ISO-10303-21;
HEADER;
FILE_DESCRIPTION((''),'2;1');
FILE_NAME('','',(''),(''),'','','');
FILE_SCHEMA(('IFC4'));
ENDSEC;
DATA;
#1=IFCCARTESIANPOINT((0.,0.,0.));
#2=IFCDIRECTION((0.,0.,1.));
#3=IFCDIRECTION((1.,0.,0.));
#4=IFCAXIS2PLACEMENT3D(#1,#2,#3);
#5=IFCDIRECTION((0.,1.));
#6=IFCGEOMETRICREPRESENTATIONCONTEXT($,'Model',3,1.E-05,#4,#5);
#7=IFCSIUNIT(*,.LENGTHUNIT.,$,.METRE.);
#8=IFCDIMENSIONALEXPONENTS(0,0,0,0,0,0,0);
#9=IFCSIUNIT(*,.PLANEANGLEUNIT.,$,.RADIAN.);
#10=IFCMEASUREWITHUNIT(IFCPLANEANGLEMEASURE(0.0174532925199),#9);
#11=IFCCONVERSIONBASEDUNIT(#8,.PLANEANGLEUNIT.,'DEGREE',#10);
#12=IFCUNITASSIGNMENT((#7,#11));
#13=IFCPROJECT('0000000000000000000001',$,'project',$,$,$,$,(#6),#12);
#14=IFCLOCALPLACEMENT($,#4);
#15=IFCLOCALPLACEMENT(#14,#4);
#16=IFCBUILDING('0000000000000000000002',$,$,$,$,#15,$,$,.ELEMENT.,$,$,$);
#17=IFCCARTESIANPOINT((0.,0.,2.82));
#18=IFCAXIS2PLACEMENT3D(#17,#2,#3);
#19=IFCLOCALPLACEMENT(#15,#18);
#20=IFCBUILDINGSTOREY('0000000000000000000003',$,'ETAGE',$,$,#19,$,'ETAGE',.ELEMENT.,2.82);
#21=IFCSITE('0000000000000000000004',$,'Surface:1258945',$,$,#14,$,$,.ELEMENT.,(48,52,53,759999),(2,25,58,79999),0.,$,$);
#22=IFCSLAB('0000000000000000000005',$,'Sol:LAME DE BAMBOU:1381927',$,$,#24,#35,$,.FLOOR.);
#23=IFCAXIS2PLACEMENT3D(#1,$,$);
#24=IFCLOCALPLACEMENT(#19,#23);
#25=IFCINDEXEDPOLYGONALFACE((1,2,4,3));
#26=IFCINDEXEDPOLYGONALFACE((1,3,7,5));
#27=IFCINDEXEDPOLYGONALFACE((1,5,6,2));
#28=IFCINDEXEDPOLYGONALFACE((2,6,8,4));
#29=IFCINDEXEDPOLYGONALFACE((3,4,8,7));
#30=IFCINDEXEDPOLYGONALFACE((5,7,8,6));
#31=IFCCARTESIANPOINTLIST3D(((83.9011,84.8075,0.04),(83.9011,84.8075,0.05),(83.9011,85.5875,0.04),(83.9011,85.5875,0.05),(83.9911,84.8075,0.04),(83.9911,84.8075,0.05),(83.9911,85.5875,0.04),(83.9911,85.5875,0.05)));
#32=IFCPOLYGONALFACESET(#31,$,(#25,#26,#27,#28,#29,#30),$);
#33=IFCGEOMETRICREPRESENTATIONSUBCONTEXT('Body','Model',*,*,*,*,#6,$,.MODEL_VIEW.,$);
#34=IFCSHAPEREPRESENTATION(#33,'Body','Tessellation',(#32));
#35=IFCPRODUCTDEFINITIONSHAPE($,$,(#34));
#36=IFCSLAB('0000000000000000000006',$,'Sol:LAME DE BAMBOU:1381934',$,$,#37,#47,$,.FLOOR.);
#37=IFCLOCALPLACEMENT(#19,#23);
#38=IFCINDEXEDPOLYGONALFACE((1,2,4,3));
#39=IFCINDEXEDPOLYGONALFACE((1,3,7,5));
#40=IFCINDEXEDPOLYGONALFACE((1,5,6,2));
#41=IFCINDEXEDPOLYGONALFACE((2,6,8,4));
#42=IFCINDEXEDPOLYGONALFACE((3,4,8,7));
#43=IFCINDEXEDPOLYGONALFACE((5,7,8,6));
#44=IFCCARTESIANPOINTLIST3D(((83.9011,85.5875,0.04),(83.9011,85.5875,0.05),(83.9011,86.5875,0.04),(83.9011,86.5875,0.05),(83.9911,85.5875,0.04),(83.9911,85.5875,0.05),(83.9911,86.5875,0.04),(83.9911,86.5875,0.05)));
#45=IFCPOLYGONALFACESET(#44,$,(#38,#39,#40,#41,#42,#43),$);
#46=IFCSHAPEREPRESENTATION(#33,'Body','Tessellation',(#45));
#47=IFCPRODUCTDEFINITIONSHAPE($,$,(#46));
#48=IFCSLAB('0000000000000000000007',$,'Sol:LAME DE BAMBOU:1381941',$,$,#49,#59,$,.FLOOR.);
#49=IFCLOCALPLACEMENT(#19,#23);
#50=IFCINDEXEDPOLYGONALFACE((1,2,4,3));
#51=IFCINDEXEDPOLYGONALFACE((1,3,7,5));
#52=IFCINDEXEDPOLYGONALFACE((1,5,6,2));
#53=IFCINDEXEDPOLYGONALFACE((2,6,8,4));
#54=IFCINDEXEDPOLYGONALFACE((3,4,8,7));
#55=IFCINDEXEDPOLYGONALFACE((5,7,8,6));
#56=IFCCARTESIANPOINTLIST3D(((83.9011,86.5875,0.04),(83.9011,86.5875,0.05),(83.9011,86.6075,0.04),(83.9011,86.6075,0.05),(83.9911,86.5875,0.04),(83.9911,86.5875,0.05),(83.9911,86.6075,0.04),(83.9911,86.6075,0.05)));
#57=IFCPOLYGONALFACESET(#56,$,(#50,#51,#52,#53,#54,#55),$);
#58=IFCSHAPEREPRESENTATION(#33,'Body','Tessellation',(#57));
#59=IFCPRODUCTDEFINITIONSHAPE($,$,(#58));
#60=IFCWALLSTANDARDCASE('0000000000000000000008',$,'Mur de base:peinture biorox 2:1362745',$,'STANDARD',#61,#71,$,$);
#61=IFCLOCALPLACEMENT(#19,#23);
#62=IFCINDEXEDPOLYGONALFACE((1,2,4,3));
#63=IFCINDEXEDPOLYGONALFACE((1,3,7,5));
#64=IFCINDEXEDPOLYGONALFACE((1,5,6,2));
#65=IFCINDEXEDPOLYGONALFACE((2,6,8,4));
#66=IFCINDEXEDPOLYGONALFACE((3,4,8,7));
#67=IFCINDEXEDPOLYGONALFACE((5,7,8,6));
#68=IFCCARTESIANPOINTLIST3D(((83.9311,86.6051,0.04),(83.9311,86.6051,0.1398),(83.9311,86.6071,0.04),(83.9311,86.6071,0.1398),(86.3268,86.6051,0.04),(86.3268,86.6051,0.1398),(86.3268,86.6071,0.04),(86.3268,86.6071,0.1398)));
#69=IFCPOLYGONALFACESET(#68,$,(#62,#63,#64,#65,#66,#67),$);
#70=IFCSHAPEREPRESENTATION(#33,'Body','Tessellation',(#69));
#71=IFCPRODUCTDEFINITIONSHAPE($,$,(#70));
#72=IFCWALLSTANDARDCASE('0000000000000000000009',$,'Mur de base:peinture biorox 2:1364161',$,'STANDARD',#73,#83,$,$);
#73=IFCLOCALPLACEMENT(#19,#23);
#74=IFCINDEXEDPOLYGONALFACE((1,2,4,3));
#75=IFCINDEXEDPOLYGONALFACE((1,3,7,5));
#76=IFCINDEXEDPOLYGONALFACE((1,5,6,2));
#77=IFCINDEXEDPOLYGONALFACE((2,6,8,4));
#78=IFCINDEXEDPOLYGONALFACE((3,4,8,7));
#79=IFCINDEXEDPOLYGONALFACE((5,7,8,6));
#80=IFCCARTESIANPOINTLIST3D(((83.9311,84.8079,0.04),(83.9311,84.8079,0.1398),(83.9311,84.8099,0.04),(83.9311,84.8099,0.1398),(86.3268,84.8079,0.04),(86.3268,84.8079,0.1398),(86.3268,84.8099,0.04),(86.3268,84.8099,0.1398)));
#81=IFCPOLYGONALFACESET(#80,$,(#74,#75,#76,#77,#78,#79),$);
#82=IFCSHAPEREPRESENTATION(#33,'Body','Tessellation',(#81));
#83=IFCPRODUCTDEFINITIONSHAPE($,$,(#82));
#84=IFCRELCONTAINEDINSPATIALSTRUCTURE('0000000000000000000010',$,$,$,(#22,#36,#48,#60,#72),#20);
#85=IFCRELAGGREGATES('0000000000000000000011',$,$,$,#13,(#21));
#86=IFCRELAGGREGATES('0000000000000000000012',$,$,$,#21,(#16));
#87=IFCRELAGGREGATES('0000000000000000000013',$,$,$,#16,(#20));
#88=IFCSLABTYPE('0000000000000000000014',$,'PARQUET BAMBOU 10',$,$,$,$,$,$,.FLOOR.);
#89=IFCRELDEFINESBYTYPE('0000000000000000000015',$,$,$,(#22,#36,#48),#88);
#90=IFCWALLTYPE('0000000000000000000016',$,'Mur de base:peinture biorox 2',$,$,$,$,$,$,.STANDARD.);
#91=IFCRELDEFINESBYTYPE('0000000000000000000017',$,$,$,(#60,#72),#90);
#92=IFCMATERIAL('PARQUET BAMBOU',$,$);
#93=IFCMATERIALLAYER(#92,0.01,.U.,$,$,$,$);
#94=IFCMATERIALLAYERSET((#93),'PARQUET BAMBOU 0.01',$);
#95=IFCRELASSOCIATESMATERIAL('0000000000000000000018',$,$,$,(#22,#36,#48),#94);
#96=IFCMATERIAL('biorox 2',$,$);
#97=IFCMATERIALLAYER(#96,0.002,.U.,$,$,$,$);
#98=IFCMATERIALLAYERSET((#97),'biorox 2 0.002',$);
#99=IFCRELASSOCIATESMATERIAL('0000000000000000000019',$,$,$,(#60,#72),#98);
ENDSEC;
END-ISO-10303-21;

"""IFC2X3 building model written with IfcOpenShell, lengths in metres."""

from ifc_helpers import new_model, entity, si_unit, converted_unit, direction, frame, origin_with_axes, place, context, subcontext, project, spatial, polyline, outline, extrude, clip, halfspace, material, layer, layer_set, layer_usage, type_object, element, save


model = new_model("IFC2X3")

# Units and contexts
model_context = context("Model", 3, precision=1e-05, world=origin_with_axes(), true_north=direction((0.0, 1.0)))
body_context = subcontext(model_context, "Body", "Model", "MODEL_VIEW")
ifc_project = project(units=[si_unit("LENGTHUNIT", "METRE"), converted_unit("PLANEANGLEUNIT", "DEGREE", entity("IfcPlaneAngleMeasure", 0.0174532925199), si_unit("PLANEANGLEUNIT", "RADIAN"), dimensions=[0, 0, 0, 0, 0, 0, 0])], contexts=[model_context])

# Site, building, storey
site_placement = place(None, origin_with_axes())
site = spatial("IfcSite", under=ifc_project, at=site_placement, Name="Surface:1258945", CompositionType="ELEMENT", RefLatitude=(48, 52, 53, 759999), RefLongitude=(2, 25, 58, 79999), RefElevation=0.0)
building_placement = place(site_placement, origin_with_axes())
building = spatial("IfcBuilding", under=site, at=building_placement, CompositionType="ELEMENT")
storey_placement = place(building_placement, frame((0.0, 0.0, 2.82), z_axis=(0.0, 0.0, 1.0), x_axis=(1.0, 0.0, 0.0)))
storey = spatial("IfcBuildingStorey", under=building, at=storey_placement, Name="ETAGE", LongName="ETAGE", CompositionType="ELEMENT", Elevation=2.82)

# Slabs
ifc_material_1 = material(Name="PARQUET BAMBOU")
ifc_layer_1 = layer(ifc_material_1, 0.01, ventilated="UNKNOWN")
ifc_layer_set_1 = layer_set([ifc_layer_1], Name="PARQUET BAMBOU 0.01")
slab_type = type_object("IfcSlabType", Name="PARQUET BAMBOU 10", PredefinedType="FLOOR")
ifc_layer_usage_1 = layer_usage(ifc_layer_set_1, "AXIS3", "NEGATIVE", 0.01)
slab_1_placement = place(storey_placement, frame((83.9011, 85.5875, 0.05), z_axis=(0.0, 0.0, 1.0), x_axis=(1.0, 0.0, 0.0)))
element("IfcSlab", 1, at=slab_1_placement, inside=storey, type_object=slab_type, material=ifc_layer_usage_1, Name="Sol:LAME DE BAMBOU:1381927", PredefinedType="FLOOR", context=body_context, shape_type="SweptSolid", body=[
    extrude(outline(polyline([(0.0, 0.0), (0.0, -0.78), (0.09, -0.78), (0.09, 0.0), (0.0, 0.0)])), frame((0.0, 0.0, -0.01), z_axis=(0.0, 0.0, 1.0), x_axis=(1.0, 0.0, 0.0)), (0.0, 0.0, 1.0), 0.01),
])
ifc_layer_usage_2 = layer_usage(ifc_layer_set_1, "AXIS3", "NEGATIVE", 0.01)
slab_2_placement = place(storey_placement, frame((83.9011, 86.5875, 0.05), z_axis=(0.0, 0.0, 1.0), x_axis=(1.0, 0.0, 0.0)))
element("IfcSlab", 2, at=slab_2_placement, inside=storey, type_object=slab_type, material=ifc_layer_usage_2, Name="Sol:LAME DE BAMBOU:1381934", PredefinedType="FLOOR", context=body_context, shape_type="SweptSolid", body=[
    extrude(outline(polyline([(0.0, 0.0), (0.0, -1.0), (0.09, -1.0), (0.09, 0.0), (0.0, 0.0)])), frame((0.0, 0.0, -0.01), z_axis=(0.0, 0.0, 1.0), x_axis=(1.0, 0.0, 0.0)), (0.0, 0.0, 1.0), 0.01),
])
ifc_layer_usage_3 = layer_usage(ifc_layer_set_1, "AXIS3", "NEGATIVE", 0.01)
slab_3_placement = place(storey_placement, frame((83.9011, 86.6075, 0.05), z_axis=(0.0, 0.0, 1.0), x_axis=(1.0, 0.0, 0.0)))
element("IfcSlab", 3, at=slab_3_placement, inside=storey, type_object=slab_type, material=ifc_layer_usage_3, Name="Sol:LAME DE BAMBOU:1381941", PredefinedType="FLOOR", context=body_context, shape_type="SweptSolid", body=[
    extrude(outline(polyline([(0.0, 0.0), (0.0, -0.02), (0.09, -0.02), (0.09, 0.0), (0.0, 0.0)])), frame((0.0, 0.0, -0.01), z_axis=(0.0, 0.0, 1.0), x_axis=(1.0, 0.0, 0.0)), (0.0, 0.0, 1.0), 0.01),
])

# Walls
ifc_material_2 = material(Name="biorox 2")
ifc_layer_2 = layer(ifc_material_2, 0.002, ventilated="UNKNOWN")
ifc_layer_set_2 = layer_set([ifc_layer_2], Name="biorox 2 0.002")
ifc_layer_usage_4 = layer_usage(ifc_layer_set_2, "AXIS2", "POSITIVE", -0.001)
wall_type_1 = type_object("IfcWallType", Name="Mur de base:peinture biorox 2", PredefinedType="STANDARD")
wall_1_placement = place(storey_placement, frame((83.9311, 86.6061, 0.04), z_axis=(0.0, 0.0, 1.0), x_axis=(1.0, 0.0, 0.0)))
element("IfcWallStandardCase", 4, at=wall_1_placement, inside=storey, type_object=wall_type_1, material=ifc_layer_usage_4, Name="Mur de base:peinture biorox 2:1362745", ObjectType="STANDARD", context=body_context, shape_type="Clipping", body=[
    clip(extrude(outline(polyline([(0.0, -0.001), (2.3957, -0.001), (2.3957, 0.001), (0.0, 0.001), (0.0, -0.001)])), origin_with_axes(), (0.0, 0.0, 1.0), 0.0998), halfspace(frame((0.0, 0.0, 0.0998), z_axis=(0.0, 0.0, -1.0), x_axis=(0.0, 1.0, 0.0)), True)),
])
ifc_layer_usage_5 = layer_usage(ifc_layer_set_2, "AXIS2", "POSITIVE", -0.001)
wall_2_placement = place(storey_placement, frame((83.9311, 84.8089, 0.04), z_axis=(0.0, 0.0, 1.0), x_axis=(1.0, 0.0, 0.0)))
element("IfcWallStandardCase", 5, at=wall_2_placement, inside=storey, type_object=wall_type_1, material=ifc_layer_usage_5, Name="Mur de base:peinture biorox 2:1364161", ObjectType="STANDARD", context=body_context, shape_type="Clipping", body=[
    clip(extrude(outline(polyline([(0.0, -0.001), (2.3957, -0.001), (2.3957, 0.001), (0.0, 0.001), (0.0, -0.001)])), origin_with_axes(), (0.0, 0.0, 1.0), 0.0998), halfspace(frame((0.0, 0.0, 0.0998), z_axis=(0.0, 0.0, -1.0), x_axis=(0.0, 1.0, 0.0)), True)),
])

save(model, "model.ifc")
